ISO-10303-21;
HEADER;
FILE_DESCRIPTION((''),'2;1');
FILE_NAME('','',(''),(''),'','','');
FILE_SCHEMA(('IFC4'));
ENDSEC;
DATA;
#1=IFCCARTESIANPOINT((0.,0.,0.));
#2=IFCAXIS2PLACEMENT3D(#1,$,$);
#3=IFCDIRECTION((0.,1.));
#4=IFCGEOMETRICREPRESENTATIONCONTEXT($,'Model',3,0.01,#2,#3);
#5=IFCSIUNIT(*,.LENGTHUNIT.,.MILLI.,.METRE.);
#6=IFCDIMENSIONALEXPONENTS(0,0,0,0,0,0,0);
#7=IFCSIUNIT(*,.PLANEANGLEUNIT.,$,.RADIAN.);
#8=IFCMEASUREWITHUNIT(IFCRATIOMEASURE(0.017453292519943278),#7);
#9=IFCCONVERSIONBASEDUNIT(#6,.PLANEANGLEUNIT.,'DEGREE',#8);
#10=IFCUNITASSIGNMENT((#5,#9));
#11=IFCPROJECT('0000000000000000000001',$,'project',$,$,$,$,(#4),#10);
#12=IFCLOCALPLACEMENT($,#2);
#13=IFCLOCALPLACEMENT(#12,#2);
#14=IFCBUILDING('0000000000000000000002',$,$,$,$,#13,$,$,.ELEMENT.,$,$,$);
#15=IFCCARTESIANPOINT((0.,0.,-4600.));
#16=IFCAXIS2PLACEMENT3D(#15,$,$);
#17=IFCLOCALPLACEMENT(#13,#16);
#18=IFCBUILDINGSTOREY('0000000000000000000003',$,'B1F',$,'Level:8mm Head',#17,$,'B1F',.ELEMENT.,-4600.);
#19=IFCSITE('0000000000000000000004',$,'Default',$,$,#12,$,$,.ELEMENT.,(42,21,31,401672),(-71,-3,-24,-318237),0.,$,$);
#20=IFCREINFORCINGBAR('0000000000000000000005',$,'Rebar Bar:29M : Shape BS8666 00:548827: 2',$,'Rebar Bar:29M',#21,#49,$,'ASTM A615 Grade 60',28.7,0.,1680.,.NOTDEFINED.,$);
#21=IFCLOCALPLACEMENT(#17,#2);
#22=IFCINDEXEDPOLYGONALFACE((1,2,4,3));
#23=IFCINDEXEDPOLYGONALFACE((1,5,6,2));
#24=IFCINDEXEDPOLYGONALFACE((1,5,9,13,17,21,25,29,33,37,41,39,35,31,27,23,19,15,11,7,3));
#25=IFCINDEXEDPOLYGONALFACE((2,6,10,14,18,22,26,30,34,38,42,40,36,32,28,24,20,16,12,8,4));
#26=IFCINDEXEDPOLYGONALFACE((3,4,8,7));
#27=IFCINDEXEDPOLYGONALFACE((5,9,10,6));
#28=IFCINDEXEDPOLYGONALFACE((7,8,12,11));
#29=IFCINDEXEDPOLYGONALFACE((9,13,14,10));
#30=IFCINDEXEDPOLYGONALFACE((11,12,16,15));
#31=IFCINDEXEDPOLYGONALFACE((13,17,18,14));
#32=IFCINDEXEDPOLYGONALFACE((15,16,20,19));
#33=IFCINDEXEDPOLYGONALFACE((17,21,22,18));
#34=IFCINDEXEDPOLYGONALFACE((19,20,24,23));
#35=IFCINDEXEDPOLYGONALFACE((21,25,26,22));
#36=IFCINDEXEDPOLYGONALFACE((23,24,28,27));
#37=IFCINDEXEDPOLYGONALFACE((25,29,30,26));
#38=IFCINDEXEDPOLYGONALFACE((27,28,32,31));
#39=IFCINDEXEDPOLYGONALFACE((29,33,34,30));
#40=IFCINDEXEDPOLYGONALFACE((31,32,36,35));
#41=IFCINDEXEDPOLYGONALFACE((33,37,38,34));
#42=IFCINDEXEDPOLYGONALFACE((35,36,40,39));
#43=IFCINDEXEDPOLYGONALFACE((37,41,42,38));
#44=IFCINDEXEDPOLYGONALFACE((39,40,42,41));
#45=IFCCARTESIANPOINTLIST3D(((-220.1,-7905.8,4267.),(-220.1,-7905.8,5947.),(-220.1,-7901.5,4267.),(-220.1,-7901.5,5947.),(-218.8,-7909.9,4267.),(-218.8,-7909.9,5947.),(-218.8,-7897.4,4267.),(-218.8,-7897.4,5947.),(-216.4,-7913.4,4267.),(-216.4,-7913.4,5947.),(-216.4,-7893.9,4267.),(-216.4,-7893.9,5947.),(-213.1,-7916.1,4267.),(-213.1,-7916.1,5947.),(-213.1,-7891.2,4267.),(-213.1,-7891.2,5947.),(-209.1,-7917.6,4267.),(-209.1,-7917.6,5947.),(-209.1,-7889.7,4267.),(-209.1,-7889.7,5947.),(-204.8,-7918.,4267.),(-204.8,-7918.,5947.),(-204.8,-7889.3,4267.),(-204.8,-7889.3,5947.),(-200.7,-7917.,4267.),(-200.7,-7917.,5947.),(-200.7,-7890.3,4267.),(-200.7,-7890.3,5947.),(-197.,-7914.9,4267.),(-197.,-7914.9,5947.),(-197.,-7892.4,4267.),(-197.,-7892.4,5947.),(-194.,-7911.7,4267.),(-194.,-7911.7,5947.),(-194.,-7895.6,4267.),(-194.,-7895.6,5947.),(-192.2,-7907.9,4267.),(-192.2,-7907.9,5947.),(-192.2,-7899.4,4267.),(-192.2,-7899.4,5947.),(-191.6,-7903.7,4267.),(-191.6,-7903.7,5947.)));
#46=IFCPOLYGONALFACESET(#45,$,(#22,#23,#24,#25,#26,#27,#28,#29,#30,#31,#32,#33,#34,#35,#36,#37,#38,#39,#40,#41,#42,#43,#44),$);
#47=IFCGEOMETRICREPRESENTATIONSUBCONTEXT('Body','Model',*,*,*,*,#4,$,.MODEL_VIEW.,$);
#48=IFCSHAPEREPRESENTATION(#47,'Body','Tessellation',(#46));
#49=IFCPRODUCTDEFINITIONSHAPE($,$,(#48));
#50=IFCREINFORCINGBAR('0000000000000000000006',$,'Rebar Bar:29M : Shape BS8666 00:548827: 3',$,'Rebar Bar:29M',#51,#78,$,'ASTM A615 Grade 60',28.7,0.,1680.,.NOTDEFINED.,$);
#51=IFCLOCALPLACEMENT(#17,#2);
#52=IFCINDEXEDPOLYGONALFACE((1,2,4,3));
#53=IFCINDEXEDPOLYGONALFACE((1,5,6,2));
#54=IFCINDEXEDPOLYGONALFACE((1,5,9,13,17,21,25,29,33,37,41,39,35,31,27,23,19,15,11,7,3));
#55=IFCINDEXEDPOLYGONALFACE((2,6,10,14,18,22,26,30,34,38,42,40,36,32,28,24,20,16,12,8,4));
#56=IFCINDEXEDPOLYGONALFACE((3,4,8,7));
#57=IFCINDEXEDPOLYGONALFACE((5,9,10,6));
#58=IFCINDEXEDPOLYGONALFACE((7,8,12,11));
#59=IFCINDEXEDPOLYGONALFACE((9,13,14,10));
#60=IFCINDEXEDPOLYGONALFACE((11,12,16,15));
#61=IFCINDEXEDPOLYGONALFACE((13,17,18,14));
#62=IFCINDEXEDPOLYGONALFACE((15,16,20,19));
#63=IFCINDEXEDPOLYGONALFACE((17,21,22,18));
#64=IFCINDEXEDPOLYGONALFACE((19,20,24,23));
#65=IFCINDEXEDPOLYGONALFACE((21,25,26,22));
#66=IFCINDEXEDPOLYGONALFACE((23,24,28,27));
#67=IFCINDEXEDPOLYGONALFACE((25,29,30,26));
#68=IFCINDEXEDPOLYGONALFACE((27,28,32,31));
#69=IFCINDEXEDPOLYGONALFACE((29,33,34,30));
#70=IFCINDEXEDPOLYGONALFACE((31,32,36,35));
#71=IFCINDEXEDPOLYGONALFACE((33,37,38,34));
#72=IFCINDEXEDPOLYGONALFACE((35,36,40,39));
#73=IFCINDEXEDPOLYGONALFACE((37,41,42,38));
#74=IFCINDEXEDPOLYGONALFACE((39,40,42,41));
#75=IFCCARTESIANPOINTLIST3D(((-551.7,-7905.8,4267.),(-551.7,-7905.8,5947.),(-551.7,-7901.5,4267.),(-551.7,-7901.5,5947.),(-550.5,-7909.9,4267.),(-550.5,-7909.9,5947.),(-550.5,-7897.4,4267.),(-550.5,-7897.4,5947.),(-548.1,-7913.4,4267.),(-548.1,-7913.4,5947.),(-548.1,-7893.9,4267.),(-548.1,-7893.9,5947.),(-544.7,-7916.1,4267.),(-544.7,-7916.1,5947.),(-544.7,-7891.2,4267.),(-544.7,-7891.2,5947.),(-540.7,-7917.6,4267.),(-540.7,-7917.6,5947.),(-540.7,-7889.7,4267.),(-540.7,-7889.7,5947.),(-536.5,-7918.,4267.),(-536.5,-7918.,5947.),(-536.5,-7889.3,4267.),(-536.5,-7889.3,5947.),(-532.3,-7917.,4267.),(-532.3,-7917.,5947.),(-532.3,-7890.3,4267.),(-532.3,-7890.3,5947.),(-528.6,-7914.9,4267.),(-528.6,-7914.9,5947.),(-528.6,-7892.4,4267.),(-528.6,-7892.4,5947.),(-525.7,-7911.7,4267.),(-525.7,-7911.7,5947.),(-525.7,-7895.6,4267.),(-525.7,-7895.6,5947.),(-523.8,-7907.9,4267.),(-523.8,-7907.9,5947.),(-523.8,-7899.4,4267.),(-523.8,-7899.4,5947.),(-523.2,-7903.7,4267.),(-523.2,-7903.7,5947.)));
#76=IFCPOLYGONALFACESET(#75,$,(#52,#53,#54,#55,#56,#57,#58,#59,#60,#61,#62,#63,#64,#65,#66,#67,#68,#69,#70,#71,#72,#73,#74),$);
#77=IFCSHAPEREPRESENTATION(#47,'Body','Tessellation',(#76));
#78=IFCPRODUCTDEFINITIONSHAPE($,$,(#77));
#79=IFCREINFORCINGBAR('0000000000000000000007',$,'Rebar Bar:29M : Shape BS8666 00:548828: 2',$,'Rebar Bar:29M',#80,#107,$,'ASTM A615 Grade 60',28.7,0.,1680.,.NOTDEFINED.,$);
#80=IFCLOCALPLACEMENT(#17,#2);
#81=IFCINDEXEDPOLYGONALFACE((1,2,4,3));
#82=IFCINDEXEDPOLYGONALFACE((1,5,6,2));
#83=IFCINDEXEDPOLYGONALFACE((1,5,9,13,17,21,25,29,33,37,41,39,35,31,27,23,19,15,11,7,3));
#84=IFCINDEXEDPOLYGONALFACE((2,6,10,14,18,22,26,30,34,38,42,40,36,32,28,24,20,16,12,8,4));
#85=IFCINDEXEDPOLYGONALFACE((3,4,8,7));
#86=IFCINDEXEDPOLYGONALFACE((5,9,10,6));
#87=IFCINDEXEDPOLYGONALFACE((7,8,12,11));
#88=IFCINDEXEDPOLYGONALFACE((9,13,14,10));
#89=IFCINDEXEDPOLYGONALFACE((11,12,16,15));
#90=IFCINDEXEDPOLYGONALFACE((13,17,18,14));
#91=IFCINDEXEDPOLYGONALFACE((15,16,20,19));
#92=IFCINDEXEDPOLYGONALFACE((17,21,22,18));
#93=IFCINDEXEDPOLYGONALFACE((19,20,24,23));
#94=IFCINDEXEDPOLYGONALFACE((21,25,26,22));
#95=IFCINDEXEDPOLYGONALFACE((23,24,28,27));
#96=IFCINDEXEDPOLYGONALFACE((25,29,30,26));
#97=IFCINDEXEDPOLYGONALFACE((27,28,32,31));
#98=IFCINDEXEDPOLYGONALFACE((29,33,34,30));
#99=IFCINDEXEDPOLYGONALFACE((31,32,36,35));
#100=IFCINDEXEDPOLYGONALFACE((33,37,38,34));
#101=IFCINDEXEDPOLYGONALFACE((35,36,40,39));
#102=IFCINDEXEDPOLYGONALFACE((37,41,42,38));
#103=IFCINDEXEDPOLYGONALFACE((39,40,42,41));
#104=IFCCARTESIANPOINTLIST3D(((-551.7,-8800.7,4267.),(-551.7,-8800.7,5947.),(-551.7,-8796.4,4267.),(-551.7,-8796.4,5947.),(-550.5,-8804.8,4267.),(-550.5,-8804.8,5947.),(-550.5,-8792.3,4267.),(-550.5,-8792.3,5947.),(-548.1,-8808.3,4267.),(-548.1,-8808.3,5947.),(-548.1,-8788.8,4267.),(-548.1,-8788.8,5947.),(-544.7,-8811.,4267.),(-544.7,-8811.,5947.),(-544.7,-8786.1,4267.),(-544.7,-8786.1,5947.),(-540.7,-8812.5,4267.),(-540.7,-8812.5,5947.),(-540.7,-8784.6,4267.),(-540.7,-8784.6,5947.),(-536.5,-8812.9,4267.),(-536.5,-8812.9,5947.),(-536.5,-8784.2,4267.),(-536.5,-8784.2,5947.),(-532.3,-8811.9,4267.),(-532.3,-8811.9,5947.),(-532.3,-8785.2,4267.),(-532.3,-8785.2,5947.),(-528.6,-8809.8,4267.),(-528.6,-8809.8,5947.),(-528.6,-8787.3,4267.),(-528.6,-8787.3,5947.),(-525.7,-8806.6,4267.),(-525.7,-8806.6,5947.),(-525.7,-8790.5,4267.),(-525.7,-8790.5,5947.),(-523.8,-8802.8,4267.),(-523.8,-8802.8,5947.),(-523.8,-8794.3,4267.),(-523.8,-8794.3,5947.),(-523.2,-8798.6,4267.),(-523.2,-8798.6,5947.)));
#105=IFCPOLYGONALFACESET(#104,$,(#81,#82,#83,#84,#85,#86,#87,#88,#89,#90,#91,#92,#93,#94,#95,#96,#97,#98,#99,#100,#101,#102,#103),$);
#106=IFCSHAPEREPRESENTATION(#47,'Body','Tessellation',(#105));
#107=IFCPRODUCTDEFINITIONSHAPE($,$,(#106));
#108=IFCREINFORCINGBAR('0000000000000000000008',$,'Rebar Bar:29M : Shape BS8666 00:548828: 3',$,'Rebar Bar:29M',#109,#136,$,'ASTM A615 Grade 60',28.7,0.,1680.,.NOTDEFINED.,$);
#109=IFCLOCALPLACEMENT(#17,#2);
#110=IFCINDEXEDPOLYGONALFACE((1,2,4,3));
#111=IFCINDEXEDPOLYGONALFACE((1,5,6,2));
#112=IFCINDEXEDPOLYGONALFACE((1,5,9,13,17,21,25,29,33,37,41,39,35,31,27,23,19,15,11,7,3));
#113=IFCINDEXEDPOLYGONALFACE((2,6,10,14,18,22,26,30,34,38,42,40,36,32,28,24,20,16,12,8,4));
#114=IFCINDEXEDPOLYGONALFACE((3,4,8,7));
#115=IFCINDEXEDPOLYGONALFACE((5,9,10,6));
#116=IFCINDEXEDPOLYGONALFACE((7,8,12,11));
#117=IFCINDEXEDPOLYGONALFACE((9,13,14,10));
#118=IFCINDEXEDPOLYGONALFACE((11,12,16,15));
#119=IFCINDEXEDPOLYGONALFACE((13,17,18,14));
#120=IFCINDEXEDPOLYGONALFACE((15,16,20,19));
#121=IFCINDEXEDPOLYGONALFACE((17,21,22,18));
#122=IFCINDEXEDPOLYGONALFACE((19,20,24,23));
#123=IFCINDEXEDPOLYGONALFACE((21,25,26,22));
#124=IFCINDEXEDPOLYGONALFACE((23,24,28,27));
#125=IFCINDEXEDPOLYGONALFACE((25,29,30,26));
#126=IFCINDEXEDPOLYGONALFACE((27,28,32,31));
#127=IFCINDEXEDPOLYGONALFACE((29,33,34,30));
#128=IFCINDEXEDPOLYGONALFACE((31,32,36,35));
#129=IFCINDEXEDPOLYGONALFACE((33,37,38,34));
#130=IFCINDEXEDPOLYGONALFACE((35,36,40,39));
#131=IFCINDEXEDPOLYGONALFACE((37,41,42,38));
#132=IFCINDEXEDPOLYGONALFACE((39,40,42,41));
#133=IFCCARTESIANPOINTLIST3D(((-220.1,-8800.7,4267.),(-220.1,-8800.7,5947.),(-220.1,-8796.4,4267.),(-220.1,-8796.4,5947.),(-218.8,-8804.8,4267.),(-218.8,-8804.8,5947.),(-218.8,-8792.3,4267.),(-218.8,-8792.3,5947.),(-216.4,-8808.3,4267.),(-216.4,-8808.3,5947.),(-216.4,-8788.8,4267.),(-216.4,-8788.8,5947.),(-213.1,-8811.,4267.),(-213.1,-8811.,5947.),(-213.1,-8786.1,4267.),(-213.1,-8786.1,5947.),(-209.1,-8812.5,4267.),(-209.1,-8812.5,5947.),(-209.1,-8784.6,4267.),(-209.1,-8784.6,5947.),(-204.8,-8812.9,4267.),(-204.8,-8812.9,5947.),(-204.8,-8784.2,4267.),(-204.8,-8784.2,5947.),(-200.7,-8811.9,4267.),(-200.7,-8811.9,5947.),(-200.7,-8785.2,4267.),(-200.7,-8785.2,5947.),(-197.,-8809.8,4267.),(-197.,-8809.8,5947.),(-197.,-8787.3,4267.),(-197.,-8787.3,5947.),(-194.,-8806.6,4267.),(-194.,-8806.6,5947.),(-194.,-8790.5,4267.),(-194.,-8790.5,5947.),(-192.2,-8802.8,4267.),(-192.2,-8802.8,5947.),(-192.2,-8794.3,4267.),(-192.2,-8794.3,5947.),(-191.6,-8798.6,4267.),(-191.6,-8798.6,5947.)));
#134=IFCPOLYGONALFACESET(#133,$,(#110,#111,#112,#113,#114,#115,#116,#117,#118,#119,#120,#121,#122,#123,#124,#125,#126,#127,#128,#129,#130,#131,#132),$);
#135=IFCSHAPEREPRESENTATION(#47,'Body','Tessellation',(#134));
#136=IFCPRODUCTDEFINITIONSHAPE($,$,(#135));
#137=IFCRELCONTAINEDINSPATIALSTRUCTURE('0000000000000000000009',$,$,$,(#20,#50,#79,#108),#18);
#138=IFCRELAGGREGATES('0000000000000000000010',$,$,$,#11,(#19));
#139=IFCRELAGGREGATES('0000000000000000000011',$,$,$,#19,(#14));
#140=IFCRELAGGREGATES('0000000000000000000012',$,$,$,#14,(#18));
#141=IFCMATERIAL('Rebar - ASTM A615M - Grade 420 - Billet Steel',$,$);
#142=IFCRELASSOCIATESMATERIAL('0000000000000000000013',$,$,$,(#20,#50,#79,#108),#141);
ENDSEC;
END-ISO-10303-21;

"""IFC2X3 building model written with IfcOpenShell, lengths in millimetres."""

from ifc_helpers import new_model, entity, si_unit, converted_unit, direction, frame, origin, place, context, subcontext, project, spatial, material, element, save


model = new_model("IFC2X3")

# Units and contexts
model_context = context("Model", 3, precision=0.01, world=origin(), true_north=direction((0.0, 1.0)))
body_context = subcontext(model_context, "Body", "Model", "MODEL_VIEW")
ifc_project = project(units=[si_unit("LENGTHUNIT", "METRE", prefix="MILLI"), converted_unit("PLANEANGLEUNIT", "DEGREE", entity("IfcRatioMeasure", 0.017453292519943278), si_unit("PLANEANGLEUNIT", "RADIAN"), dimensions=[0, 0, 0, 0, 0, 0, 0])], contexts=[model_context])

# Site, building, storey
site_placement = place(None, origin())
site = spatial("IfcSite", under=ifc_project, at=site_placement, Name="Default", CompositionType="ELEMENT", RefLatitude=(42, 21, 31, 401672), RefLongitude=(-71, -3, -24, -318237), RefElevation=0.0)
building_placement = place(site_placement, origin())
building = spatial("IfcBuilding", under=site, at=building_placement, CompositionType="ELEMENT")
storey_placement = place(building_placement, frame((0.0, 0.0, -4600.0)))
storey = spatial("IfcBuildingStorey", under=building, at=storey_placement, Name="B1F", ObjectType="Level:8mm Head", LongName="B1F", CompositionType="ELEMENT", Elevation=-4600.0)

# Reinforcing bars
ifc_material = material(Name="Rebar - ASTM A615M - Grade 420 - Billet Steel")
reinforcing_bar_1_placement = place(storey_placement, origin())
element("IfcReinforcingBar", 1, at=reinforcing_bar_1_placement, inside=storey, material=ifc_material, Name="Rebar Bar:29M : Shape BS8666 00:548827: 2", SteelGrade="ASTM A615 Grade 60", ObjectType="Rebar Bar:29M", BarLength=1680.0, BarRole="NOTDEFINED", CrossSectionArea=0.0, NominalDiameter=28.7, context=body_context, shape_type="AdvancedSweptSolid", body=[
    entity("IfcSweptDiskSolid", entity("IfcCompositeCurve", [entity("IfcCompositeCurveSegment", "CONTINUOUS", True, entity("IfcPolyline", [entity("IfcCartesianPoint", [-205.9, -7903.7, 4267.0]), entity("IfcCartesianPoint", [-205.9, -7903.7, 5947.0])]))], False), 14.3, None, 0.0, 1.0),
])
reinforcing_bar_2_placement = place(storey_placement, origin())
element("IfcReinforcingBar", 2, at=reinforcing_bar_2_placement, inside=storey, material=ifc_material, Name="Rebar Bar:29M : Shape BS8666 00:548827: 3", SteelGrade="ASTM A615 Grade 60", ObjectType="Rebar Bar:29M", BarLength=1680.0, BarRole="NOTDEFINED", CrossSectionArea=0.0, NominalDiameter=28.7, context=body_context, shape_type="AdvancedSweptSolid", body=[
    entity("IfcSweptDiskSolid", entity("IfcCompositeCurve", [entity("IfcCompositeCurveSegment", "CONTINUOUS", True, entity("IfcPolyline", [entity("IfcCartesianPoint", [-537.5, -7903.7, 4267.0]), entity("IfcCartesianPoint", [-537.5, -7903.7, 5947.0])]))], False), 14.3, None, 0.0, 1.0),
])
reinforcing_bar_3_placement = place(storey_placement, origin())
element("IfcReinforcingBar", 3, at=reinforcing_bar_3_placement, inside=storey, material=ifc_material, Name="Rebar Bar:29M : Shape BS8666 00:548828: 2", SteelGrade="ASTM A615 Grade 60", ObjectType="Rebar Bar:29M", BarLength=1680.0, BarRole="NOTDEFINED", CrossSectionArea=0.0, NominalDiameter=28.7, context=body_context, shape_type="AdvancedSweptSolid", body=[
    entity("IfcSweptDiskSolid", entity("IfcCompositeCurve", [entity("IfcCompositeCurveSegment", "CONTINUOUS", True, entity("IfcPolyline", [entity("IfcCartesianPoint", [-537.5, -8798.6, 4267.0]), entity("IfcCartesianPoint", [-537.5, -8798.6, 5947.0])]))], False), 14.3, None, 0.0, 1.0),
])
reinforcing_bar_4_placement = place(storey_placement, origin())
element("IfcReinforcingBar", 4, at=reinforcing_bar_4_placement, inside=storey, material=ifc_material, Name="Rebar Bar:29M : Shape BS8666 00:548828: 3", SteelGrade="ASTM A615 Grade 60", ObjectType="Rebar Bar:29M", BarLength=1680.0, BarRole="NOTDEFINED", CrossSectionArea=0.0, NominalDiameter=28.7, context=body_context, shape_type="AdvancedSweptSolid", body=[
    entity("IfcSweptDiskSolid", entity("IfcCompositeCurve", [entity("IfcCompositeCurveSegment", "CONTINUOUS", True, entity("IfcPolyline", [entity("IfcCartesianPoint", [-205.9, -8798.6, 4267.0]), entity("IfcCartesianPoint", [-205.9, -8798.6, 5947.0])]))], False), 14.3, None, 0.0, 1.0),
])

save(model, "model.ifc")
